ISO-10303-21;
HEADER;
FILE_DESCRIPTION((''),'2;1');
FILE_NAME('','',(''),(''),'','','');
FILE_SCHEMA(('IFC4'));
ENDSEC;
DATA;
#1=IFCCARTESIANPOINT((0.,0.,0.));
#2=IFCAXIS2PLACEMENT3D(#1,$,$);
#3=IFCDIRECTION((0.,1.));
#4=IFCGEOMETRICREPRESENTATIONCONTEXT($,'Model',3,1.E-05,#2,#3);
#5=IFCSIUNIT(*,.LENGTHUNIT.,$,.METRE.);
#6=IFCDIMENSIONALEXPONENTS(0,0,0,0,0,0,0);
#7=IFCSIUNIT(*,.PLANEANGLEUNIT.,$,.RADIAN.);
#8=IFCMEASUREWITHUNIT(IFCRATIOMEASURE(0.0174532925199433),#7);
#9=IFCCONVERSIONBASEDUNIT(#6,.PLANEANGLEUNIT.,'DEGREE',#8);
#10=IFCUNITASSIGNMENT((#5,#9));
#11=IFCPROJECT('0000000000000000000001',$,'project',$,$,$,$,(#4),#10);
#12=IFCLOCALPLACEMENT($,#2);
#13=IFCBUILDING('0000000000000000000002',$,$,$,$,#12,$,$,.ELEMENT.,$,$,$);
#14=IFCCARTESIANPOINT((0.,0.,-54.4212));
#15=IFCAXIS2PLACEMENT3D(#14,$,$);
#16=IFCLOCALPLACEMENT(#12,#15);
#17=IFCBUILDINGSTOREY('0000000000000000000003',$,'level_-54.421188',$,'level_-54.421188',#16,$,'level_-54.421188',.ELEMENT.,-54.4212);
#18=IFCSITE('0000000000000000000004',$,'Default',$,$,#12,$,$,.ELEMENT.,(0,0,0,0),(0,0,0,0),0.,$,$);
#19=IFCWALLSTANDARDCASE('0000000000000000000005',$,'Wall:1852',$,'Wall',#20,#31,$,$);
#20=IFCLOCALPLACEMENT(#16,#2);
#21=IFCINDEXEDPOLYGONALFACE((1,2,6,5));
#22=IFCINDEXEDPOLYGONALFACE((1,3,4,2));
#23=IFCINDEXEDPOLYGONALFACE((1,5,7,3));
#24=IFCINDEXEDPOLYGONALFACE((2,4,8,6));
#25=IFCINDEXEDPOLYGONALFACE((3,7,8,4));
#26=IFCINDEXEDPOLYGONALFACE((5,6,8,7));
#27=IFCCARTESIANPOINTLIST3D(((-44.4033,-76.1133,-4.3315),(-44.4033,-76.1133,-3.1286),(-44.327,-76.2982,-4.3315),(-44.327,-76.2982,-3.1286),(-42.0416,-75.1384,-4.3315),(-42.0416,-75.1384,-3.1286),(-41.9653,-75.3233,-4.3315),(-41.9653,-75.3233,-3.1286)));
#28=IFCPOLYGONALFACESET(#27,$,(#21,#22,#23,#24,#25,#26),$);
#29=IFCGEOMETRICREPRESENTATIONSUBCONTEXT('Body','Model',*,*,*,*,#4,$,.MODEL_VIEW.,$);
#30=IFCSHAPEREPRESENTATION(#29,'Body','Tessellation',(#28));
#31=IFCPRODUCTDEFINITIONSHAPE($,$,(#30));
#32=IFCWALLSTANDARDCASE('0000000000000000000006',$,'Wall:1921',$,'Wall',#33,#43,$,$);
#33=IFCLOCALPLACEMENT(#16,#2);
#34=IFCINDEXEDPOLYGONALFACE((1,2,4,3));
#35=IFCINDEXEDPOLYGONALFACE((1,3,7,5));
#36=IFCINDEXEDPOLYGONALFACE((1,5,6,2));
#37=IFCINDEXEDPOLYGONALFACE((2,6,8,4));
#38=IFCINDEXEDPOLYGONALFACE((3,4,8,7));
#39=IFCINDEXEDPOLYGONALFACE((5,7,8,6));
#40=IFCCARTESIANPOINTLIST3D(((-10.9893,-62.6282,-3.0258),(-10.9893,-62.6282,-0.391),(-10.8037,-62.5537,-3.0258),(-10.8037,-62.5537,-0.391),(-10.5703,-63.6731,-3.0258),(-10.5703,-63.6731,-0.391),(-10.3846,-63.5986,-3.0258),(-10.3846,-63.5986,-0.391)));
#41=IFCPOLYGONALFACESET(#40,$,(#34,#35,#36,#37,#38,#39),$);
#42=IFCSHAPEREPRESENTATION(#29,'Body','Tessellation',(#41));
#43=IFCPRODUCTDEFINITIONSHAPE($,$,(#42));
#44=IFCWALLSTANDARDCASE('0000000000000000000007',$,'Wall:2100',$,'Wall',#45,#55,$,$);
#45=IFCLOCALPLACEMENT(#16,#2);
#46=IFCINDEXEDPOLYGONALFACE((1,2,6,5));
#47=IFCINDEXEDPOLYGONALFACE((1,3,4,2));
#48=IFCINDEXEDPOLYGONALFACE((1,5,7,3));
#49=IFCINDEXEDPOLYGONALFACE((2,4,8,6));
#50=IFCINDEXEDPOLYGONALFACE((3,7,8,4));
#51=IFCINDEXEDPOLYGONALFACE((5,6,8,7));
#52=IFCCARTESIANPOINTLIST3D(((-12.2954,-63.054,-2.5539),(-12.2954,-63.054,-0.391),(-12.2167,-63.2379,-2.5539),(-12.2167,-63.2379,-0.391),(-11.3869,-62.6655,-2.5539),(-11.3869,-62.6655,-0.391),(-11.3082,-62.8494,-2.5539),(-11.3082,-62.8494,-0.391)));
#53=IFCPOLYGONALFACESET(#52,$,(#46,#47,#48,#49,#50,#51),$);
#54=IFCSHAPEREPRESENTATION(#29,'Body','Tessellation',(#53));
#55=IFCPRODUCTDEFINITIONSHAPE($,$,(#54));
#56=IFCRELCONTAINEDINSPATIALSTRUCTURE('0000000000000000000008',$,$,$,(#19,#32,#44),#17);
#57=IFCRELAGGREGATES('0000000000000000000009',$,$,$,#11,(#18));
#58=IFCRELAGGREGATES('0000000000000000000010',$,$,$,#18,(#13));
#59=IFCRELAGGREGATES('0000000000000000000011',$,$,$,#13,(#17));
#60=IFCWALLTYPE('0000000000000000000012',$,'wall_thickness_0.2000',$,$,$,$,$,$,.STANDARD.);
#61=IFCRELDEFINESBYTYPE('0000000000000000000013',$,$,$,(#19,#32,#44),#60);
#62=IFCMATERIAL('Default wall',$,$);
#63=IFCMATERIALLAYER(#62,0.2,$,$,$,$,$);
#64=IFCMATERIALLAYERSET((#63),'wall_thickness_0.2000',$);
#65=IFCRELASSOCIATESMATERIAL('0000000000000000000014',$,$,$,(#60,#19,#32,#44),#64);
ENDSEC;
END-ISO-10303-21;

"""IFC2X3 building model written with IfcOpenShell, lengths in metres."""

from ifc_helpers import new_model, entity, si_unit, converted_unit, direction, frame, origin, place, context, subcontext, project, spatial, polyline, outline, extrude, material, layer, layer_set, layer_usage, type_object, element, save


model = new_model("IFC2X3")

# Units and contexts
model_context = context("Model", 3, precision=1e-05, world=origin(), true_north=direction((0.0, 1.0)))
body_context = subcontext(model_context, "Body", "Model", "MODEL_VIEW")
ifc_project = project(units=[si_unit("LENGTHUNIT", "METRE"), converted_unit("PLANEANGLEUNIT", "DEGREE", entity("IfcRatioMeasure", 0.0174532925199433), si_unit("PLANEANGLEUNIT", "RADIAN"), dimensions=[0, 0, 0, 0, 0, 0, 0])], contexts=[model_context])

# Site, building, storey
placement_1 = place(None, origin())
site = spatial("IfcSite", under=ifc_project, at=placement_1, Name="Default", CompositionType="ELEMENT", RefLatitude=(0, 0, 0, 0), RefLongitude=(0, 0, 0, 0), RefElevation=0.0)
building = spatial("IfcBuilding", under=site, at=placement_1, CompositionType="ELEMENT")
storey_placement = place(placement_1, frame((0.0, 0.0, -54.4212)))
storey = spatial("IfcBuildingStorey", under=building, at=storey_placement, Name="level_-54.421188", ObjectType="level_-54.421188", LongName="level_-54.421188", CompositionType="ELEMENT", Elevation=-54.4212)

# Shared definitions
ifc_material_1 = material(Name="Default wall")
ifc_layer = layer(ifc_material_1, 0.2)
ifc_layer_set = layer_set([ifc_layer], Name="wall_thickness_0.2000")
ifc_layer_usage = layer_usage(ifc_layer_set, "AXIS2", "POSITIVE", -0.1)
wall_type = type_object("IfcWallType", Name="wall_thickness_0.2000", PredefinedType="STANDARD", material=ifc_layer_set)

# Walls
placement_2 = place(placement_1, frame((0.0, 0.0, -58.7527)))
wall_1_placement = place(placement_2, frame((-44.3651, -76.2057, 0.0), z_axis=(0.0, 0.0, 1.0), x_axis=(0.924346, 0.381556, 0.0)))
element("IfcWallStandardCase", 1, at=wall_1_placement, inside=storey, type_object=wall_type, material=ifc_layer_usage, Name="Wall:1852", ObjectType="Wall", context=body_context, shape_type="SweptSolid", body=[
    extrude(outline(polyline([(2.555, -0.1), (2.555, 0.1), (0.0, 0.1), (0.0, -0.1), (2.555, -0.1)])), origin(), (0.0, 0.0, 1.0), 1.2029),
])
placement_3 = place(placement_1, frame((0.0, 0.0, -57.447)))
wall_2_placement = place(placement_3, frame((-10.4775, -63.6358, 0.0), z_axis=(0.0, 0.0, 1.0), x_axis=(-0.37224, 0.928137, 0.0)))
element("IfcWallStandardCase", 2, at=wall_2_placement, inside=storey, type_object=wall_type, material=ifc_layer_usage, Name="Wall:1921", ObjectType="Wall", context=body_context, shape_type="SweptSolid", body=[
    extrude(outline(polyline([(1.1258, -0.1), (1.1258, 0.1), (0.0, 0.1), (0.0, -0.1), (1.1258, -0.1)])), origin(), (0.0, 0.0, 1.0), 2.6348),
])
placement_4 = place(placement_1, frame((0.0, 0.0, -56.9751)))
wall_3_placement = place(placement_4, frame((-11.3475, -62.7574, 0.0), z_axis=(0.0, 0.0, 1.0), x_axis=(-0.919453, -0.393199, 0.0)))
element("IfcWallStandardCase", 3, at=wall_3_placement, inside=storey, type_object=wall_type, material=ifc_layer_usage, Name="Wall:2100", ObjectType="Wall", context=body_context, shape_type="SweptSolid", body=[
    extrude(outline(polyline([(0.9881, -0.1), (0.9881, 0.1), (0.0, 0.1), (0.0, -0.1), (0.9881, -0.1)])), origin(), (0.0, 0.0, 1.0), 2.1629),
])

save(model, "model.ifc")
